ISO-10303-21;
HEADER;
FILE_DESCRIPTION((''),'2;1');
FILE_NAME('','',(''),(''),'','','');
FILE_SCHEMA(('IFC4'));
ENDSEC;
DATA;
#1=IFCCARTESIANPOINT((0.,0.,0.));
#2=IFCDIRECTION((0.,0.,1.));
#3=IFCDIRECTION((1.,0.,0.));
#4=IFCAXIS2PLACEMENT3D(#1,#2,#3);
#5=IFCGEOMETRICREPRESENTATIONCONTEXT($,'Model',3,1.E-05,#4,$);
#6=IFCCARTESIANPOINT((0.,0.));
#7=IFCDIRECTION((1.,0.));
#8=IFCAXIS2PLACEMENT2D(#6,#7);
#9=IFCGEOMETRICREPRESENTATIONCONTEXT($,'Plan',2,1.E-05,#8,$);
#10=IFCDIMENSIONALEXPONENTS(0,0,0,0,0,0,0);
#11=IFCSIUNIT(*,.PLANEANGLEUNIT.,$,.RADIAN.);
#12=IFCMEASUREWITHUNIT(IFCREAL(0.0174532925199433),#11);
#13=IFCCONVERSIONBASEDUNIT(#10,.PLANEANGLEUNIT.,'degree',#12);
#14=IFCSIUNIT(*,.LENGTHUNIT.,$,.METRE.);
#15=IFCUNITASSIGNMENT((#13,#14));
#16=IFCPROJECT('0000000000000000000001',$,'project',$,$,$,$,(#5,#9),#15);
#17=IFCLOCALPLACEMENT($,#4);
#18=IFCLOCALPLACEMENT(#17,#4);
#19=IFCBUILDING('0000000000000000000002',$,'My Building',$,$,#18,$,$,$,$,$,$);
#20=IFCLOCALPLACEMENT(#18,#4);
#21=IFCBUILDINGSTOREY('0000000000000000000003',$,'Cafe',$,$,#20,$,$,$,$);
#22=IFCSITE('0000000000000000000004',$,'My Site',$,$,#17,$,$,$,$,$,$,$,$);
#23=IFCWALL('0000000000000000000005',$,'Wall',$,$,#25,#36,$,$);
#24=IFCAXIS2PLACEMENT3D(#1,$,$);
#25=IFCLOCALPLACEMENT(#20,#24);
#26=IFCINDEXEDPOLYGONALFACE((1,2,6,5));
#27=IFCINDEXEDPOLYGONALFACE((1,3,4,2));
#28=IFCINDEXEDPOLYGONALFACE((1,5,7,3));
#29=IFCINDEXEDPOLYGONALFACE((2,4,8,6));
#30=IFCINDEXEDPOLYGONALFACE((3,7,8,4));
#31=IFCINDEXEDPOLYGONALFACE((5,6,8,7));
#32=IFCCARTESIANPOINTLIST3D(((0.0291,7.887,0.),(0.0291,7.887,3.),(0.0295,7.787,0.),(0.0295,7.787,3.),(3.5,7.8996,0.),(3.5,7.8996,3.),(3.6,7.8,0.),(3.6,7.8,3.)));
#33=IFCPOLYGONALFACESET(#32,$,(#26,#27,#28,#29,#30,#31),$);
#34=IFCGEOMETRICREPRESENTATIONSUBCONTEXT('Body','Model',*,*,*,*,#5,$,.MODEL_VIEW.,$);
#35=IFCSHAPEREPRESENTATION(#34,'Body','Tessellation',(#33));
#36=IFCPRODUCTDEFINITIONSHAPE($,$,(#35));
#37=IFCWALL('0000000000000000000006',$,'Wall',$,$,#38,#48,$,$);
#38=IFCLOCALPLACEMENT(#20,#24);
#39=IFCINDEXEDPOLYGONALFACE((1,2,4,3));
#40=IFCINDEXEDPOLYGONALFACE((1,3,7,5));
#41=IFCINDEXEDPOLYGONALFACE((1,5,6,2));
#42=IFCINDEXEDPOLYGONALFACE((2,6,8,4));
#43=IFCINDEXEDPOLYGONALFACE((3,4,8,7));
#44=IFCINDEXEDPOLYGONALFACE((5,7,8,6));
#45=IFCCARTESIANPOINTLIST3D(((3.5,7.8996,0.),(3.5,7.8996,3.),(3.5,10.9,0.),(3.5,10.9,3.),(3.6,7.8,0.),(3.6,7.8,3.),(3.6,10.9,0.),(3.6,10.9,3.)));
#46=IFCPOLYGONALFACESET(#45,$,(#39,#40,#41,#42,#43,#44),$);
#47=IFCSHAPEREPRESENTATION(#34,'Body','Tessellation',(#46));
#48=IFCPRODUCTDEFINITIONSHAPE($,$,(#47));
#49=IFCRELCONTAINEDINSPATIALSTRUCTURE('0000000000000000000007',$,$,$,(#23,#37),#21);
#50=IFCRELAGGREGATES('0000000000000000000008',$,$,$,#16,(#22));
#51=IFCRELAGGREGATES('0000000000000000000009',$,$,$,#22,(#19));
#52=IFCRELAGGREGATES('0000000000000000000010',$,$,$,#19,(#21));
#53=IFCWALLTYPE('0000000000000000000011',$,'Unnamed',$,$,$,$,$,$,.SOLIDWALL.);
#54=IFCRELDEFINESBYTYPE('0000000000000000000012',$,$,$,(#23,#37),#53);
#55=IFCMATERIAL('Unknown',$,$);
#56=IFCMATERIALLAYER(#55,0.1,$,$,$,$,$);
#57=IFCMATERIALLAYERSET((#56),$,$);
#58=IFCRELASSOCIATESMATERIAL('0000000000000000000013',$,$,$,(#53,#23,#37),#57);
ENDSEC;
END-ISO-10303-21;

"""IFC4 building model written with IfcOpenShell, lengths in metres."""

from ifc_helpers import new_model, entity, si_unit, converted_unit, frame, origin_with_axes, origin_2d_with_axis, place, context, subcontext, project, spatial, line, indexed_curve, outline, extrude, material, layer, layer_set, layer_usage, type_object, element, save


model = new_model("IFC4")

# Units and contexts
model_context = context("Model", 3, precision=1e-05, world=origin_with_axes())
plan_context = context("Plan", 2, precision=1e-05, world=origin_2d_with_axis())
body_context = subcontext(model_context, "Body", "Model", "MODEL_VIEW")
ifc_project = project(units=[converted_unit("PLANEANGLEUNIT", "degree", entity("IfcReal", 0.0174532925199433), si_unit("PLANEANGLEUNIT", "RADIAN"), dimensions=[0, 0, 0, 0, 0, 0, 0]), si_unit("LENGTHUNIT", "METRE")], contexts=[model_context, plan_context])

# Site, building, storey
site_placement = place(None, origin_with_axes())
site = spatial("IfcSite", under=ifc_project, at=site_placement, Name="My Site")
building_placement = place(site_placement, origin_with_axes())
building = spatial("IfcBuilding", under=site, at=building_placement, Name="My Building")
storey_placement = place(building_placement, origin_with_axes())
storey = spatial("IfcBuildingStorey", under=building, at=storey_placement, Name="Cafe")

# Shared definitions
ifc_material = material(Name="Unknown")

# Walls
ifc_layer_1 = layer(ifc_material, 0.1)
ifc_layer_set_1 = layer_set([ifc_layer_1])
wall_type = type_object("IfcWallType", Name="Unnamed", PredefinedType="SOLIDWALL", material=ifc_layer_set_1)
ifc_layer_usage_1 = layer_usage(ifc_layer_set_1, "AXIS2", "POSITIVE", 0.0)
wall_1_placement = place(storey_placement, frame((0.0295, 7.787, 0.0), z_axis=(0.0, 0.0, 1.0), x_axis=(0.999993, 0.003653, 0.0)))
element("IfcWall", 1, at=wall_1_placement, inside=storey, type_object=wall_type, material=ifc_layer_usage_1, Name="Wall", context=body_context, shape_type="SweptSolid", body=[
    extrude(outline(indexed_curve([(0.0, 0.0), (0.0, 0.1), (3.4709, 0.1), (3.5705, 0.0)], segments=[line(1, 2, 3, 4, 1)])), origin_with_axes(), (0.0, 0.0, 1.0), 3.0),
])
ifc_layer_usage_2 = layer_usage(ifc_layer_set_1, "AXIS2", "POSITIVE", 0.0)
wall_2_placement = place(storey_placement, frame((3.6, 7.8, 0.0), z_axis=(0.0, 0.0, 1.0), x_axis=(0.0, 1.0, 0.0)))
element("IfcWall", 2, at=wall_2_placement, inside=storey, type_object=wall_type, material=ifc_layer_usage_2, Name="Wall", context=body_context, shape_type="SweptSolid", body=[
    extrude(outline(indexed_curve([(0.0, 0.0), (0.0996, 0.1), (3.1, 0.1), (3.1, 0.0)], segments=[line(1, 2, 3, 4, 1)])), origin_with_axes(), (0.0, 0.0, 1.0), 3.0),
])

save(model, "model.ifc")
